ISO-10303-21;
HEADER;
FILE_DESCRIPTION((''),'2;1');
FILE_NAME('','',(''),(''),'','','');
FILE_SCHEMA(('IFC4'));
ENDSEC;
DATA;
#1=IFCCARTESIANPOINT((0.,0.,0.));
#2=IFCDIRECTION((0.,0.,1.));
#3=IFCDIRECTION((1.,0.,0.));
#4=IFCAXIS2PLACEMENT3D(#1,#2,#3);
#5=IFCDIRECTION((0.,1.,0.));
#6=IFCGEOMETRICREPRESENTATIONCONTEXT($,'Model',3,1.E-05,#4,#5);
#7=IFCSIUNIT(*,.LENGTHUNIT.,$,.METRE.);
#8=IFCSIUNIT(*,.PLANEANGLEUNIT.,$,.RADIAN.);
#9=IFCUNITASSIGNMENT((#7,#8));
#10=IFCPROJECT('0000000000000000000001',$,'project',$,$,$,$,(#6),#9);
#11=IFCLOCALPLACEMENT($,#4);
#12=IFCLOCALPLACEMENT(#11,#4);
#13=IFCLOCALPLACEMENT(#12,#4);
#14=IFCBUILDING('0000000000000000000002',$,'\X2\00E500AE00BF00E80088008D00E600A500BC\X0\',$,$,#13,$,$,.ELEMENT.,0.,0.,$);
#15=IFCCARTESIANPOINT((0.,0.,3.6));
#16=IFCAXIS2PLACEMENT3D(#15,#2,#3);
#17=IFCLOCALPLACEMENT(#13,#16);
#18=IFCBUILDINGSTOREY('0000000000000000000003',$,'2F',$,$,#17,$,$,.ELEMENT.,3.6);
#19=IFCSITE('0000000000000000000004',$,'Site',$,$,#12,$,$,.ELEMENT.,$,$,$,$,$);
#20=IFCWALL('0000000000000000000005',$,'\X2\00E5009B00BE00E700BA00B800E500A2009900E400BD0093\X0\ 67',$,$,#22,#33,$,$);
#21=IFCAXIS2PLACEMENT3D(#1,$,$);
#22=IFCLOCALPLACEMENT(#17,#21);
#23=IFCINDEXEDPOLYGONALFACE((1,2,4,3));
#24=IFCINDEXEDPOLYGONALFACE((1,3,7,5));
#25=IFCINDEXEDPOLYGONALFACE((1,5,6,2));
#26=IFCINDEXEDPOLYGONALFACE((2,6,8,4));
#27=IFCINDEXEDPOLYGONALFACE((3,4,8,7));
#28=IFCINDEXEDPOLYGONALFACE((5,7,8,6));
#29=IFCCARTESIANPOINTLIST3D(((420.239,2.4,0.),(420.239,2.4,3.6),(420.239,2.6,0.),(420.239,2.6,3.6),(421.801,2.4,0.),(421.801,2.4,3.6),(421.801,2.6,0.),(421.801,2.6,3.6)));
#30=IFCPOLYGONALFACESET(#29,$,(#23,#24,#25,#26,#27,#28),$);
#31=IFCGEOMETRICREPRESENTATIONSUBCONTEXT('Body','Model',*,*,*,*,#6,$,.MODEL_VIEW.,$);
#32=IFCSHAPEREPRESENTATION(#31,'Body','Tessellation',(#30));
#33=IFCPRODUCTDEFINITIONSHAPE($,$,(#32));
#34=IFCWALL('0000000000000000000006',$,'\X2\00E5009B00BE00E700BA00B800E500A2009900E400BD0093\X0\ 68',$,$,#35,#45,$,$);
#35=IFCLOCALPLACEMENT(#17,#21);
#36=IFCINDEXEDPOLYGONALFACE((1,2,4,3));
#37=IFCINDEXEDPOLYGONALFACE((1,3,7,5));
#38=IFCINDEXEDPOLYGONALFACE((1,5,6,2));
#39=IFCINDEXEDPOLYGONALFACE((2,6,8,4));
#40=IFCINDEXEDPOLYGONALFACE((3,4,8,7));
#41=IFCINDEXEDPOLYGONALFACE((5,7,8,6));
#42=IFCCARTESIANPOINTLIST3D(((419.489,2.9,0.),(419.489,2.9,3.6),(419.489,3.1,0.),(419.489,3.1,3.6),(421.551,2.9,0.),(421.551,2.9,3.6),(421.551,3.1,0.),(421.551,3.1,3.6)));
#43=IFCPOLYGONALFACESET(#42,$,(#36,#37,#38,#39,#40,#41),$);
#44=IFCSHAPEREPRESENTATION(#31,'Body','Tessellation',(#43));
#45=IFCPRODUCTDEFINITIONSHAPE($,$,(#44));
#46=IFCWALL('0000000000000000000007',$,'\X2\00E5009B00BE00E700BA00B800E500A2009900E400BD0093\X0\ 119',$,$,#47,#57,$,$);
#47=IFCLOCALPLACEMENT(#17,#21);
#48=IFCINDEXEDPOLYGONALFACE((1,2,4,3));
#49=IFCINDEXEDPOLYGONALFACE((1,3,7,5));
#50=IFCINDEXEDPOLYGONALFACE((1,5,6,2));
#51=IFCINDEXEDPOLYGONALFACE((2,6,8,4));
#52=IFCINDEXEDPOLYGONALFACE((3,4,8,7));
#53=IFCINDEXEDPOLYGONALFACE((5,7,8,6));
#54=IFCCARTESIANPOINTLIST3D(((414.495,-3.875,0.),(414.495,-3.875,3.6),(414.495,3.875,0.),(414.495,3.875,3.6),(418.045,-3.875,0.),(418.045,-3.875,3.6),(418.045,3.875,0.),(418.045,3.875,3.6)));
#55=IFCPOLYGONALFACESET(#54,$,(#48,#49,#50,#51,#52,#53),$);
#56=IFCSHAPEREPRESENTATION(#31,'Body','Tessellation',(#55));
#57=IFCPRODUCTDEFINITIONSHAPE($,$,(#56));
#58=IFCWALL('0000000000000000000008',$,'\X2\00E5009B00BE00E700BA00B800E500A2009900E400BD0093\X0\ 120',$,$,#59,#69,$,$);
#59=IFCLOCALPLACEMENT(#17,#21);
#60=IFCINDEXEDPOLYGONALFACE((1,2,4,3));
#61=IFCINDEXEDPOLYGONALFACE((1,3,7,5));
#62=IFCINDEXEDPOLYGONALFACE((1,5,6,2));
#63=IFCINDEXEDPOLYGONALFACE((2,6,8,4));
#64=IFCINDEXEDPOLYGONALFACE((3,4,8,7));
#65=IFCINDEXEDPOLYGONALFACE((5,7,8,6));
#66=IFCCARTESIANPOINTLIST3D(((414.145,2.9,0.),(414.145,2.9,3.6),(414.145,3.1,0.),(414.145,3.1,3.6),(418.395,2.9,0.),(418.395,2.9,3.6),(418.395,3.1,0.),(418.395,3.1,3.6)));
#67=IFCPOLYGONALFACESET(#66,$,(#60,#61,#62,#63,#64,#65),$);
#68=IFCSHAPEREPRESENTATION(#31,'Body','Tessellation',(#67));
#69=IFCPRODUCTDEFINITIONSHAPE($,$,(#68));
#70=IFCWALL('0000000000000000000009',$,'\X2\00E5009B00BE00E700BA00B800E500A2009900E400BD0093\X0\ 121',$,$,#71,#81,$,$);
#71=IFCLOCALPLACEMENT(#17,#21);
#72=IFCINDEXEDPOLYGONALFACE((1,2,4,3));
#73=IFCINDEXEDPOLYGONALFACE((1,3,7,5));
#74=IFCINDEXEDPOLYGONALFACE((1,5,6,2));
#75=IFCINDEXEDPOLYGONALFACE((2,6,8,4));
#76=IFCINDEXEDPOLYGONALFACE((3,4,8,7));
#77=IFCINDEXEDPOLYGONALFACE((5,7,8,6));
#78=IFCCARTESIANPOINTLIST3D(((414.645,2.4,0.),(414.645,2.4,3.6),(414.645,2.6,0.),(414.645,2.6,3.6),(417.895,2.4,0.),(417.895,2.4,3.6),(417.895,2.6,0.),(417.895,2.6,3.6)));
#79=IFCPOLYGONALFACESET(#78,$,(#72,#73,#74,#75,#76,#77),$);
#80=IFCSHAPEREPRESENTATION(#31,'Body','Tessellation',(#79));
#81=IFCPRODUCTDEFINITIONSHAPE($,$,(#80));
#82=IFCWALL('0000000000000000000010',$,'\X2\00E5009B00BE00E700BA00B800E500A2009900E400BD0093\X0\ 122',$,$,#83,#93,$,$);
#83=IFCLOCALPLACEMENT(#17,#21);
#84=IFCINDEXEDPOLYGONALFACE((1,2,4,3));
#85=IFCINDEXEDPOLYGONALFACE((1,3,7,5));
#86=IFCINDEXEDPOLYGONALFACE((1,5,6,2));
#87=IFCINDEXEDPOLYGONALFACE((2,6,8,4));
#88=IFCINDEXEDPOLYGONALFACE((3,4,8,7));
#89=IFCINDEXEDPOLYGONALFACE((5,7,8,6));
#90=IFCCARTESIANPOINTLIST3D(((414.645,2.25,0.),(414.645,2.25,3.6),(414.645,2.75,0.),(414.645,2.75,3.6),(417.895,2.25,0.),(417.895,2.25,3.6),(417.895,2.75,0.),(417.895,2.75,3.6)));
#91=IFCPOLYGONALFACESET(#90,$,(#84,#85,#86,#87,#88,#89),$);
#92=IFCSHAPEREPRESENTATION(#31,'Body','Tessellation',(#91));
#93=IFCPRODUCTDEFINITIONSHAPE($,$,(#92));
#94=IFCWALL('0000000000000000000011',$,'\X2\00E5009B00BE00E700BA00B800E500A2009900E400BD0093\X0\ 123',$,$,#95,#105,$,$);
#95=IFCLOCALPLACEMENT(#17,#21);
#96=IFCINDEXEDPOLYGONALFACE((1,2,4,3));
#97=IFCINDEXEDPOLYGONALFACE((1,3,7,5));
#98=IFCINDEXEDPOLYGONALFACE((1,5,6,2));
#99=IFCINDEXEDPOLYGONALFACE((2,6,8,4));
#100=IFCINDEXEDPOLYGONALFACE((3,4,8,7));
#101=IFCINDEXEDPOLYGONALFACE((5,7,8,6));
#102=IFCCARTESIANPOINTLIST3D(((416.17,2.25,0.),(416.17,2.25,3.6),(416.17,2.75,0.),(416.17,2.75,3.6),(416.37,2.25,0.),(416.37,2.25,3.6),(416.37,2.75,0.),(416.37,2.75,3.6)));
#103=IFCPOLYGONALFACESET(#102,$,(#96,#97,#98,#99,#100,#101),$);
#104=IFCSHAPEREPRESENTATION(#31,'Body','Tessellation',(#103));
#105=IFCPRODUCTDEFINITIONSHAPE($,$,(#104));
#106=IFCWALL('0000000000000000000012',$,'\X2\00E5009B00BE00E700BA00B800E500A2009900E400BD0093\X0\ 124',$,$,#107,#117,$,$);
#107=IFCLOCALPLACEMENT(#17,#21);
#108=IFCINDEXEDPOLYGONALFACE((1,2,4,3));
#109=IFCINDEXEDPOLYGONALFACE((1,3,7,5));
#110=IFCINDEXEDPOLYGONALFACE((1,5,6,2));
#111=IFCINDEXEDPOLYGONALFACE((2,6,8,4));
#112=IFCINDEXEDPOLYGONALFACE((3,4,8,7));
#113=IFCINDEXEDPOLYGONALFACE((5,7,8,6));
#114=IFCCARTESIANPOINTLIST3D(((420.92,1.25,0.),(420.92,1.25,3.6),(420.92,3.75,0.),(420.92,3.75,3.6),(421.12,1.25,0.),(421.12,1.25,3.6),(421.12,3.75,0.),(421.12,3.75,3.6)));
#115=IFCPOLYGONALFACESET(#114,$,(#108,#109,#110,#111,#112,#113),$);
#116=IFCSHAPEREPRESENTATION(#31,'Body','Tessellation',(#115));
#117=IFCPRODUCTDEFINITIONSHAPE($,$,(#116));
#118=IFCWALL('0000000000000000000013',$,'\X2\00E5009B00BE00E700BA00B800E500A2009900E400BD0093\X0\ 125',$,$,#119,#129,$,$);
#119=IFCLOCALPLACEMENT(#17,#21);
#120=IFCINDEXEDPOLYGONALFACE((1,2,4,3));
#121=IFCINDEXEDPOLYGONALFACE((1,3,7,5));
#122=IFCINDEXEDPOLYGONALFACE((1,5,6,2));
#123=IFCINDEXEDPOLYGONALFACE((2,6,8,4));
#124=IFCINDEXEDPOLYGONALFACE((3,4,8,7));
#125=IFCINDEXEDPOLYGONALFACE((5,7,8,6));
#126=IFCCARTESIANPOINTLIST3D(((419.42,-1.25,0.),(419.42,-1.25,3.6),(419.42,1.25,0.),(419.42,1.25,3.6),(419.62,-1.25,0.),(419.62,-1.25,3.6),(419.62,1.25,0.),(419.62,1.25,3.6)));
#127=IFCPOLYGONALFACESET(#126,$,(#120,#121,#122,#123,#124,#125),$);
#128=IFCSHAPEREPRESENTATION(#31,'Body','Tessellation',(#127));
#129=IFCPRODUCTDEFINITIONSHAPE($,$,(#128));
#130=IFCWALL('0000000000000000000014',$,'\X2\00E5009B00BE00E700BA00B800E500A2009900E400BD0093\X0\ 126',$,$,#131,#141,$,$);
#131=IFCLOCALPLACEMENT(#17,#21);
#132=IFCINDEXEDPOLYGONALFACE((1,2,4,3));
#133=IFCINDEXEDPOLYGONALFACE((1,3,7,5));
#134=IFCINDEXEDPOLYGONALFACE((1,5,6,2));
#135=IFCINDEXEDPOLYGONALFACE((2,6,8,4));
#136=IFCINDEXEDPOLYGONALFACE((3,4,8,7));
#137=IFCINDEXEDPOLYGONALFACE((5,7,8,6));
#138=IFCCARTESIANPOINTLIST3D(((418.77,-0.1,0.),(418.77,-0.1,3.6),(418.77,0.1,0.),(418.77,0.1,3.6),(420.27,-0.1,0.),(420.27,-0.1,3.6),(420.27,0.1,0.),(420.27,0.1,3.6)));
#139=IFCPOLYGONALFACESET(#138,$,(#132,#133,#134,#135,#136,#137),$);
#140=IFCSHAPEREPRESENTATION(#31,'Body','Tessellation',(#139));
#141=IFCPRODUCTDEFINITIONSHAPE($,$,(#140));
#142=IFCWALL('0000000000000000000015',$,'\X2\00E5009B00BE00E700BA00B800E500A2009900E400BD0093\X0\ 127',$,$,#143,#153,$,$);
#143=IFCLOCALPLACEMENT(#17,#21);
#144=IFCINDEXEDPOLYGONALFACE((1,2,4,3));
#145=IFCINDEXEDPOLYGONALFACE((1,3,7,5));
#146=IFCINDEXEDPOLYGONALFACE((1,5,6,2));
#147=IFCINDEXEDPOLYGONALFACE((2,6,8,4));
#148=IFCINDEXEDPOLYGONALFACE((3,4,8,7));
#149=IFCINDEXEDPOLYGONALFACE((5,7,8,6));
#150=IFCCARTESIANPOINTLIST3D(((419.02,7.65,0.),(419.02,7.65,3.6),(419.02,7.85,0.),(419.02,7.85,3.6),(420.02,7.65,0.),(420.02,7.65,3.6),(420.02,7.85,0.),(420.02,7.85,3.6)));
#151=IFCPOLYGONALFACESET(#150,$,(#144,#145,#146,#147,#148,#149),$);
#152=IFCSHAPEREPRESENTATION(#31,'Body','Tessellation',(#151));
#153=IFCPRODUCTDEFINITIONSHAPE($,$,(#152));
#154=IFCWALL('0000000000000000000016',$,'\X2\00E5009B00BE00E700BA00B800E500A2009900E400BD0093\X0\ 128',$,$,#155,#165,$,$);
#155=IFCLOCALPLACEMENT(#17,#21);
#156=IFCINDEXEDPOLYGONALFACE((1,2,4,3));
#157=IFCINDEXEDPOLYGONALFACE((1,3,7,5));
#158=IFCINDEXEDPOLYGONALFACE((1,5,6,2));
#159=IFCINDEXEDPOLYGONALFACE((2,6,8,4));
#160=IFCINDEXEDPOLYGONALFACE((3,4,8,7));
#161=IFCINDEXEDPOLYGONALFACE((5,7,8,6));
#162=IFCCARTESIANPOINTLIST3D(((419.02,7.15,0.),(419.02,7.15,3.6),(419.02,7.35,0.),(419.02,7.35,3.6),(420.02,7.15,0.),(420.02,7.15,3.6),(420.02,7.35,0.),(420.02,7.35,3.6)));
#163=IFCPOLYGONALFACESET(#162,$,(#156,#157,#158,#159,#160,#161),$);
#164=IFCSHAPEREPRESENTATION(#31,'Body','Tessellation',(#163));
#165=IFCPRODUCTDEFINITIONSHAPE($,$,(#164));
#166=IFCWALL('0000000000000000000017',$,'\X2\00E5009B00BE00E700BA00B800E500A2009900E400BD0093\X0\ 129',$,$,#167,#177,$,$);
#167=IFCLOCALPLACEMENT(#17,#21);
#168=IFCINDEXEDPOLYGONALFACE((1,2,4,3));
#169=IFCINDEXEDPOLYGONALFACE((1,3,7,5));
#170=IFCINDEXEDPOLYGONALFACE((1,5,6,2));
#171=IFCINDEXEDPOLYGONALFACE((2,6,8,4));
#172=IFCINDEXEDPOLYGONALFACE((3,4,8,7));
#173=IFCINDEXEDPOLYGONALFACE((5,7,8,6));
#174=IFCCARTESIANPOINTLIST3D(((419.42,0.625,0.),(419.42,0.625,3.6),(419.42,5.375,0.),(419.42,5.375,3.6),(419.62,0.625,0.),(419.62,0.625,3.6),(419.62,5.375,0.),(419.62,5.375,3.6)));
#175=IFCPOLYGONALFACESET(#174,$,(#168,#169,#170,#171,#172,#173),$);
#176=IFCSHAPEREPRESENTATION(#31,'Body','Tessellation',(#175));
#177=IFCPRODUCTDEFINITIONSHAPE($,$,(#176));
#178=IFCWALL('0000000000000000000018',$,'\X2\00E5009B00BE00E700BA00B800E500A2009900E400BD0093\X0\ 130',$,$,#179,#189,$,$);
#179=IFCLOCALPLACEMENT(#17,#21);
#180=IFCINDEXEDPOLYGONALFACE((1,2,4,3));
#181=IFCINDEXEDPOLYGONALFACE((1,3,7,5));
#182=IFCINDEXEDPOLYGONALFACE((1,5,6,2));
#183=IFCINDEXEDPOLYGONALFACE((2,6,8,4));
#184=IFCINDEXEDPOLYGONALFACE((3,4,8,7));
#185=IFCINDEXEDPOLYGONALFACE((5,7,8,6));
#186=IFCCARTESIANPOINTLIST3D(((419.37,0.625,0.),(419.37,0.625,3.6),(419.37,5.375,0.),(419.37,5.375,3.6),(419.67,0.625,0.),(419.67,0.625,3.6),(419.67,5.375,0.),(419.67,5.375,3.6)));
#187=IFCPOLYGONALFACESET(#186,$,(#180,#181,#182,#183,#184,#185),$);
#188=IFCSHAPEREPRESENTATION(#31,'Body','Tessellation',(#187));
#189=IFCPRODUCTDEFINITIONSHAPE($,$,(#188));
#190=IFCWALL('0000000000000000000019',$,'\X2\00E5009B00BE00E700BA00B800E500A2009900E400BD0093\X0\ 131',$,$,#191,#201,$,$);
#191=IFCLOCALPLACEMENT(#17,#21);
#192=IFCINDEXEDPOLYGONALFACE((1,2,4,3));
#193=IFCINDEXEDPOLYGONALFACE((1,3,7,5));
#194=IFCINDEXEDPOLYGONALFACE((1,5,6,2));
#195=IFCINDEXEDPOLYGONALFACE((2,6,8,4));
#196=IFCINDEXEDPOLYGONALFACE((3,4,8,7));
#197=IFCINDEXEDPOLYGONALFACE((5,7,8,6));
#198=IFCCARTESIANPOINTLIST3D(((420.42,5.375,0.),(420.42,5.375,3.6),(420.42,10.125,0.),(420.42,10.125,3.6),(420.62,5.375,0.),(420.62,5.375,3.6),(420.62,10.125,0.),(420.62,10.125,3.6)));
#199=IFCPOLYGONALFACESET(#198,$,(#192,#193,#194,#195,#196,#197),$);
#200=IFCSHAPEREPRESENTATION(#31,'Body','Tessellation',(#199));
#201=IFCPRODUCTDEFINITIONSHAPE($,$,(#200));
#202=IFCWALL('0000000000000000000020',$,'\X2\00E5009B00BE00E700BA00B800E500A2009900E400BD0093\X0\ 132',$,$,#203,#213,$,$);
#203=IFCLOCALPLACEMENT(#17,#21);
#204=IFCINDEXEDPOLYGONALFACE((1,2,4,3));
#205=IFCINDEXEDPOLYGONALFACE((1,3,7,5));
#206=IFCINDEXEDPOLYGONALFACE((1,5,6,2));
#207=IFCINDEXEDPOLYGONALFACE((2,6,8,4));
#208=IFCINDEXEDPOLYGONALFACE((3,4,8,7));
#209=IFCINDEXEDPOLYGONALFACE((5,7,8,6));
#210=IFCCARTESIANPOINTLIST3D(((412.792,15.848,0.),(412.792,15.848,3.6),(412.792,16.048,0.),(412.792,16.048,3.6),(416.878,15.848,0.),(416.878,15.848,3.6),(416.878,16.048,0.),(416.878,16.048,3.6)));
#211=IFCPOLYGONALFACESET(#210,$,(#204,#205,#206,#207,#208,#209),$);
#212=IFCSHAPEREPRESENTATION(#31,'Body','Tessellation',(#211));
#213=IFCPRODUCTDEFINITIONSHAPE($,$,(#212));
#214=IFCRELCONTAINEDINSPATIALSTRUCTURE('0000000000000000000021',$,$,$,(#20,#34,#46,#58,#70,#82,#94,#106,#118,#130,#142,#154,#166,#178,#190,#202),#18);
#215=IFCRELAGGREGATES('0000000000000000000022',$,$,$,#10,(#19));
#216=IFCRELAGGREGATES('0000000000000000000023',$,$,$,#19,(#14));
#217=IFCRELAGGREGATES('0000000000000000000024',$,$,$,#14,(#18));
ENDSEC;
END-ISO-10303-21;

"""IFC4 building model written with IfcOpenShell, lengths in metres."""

from ifc_helpers import new_model, si_unit, direction, frame, frame_2d, origin_with_axes, place, context, subcontext, project, spatial, rectangle, extrude, element, save


model = new_model("IFC4")

# Units and contexts
model_context = context("Model", 3, precision=1e-05, world=origin_with_axes(), true_north=direction((0.0, 1.0, 0.0)))
body_context = subcontext(model_context, "Body", "Model", "MODEL_VIEW")
ifc_project = project(units=[si_unit("LENGTHUNIT", "METRE"), si_unit("PLANEANGLEUNIT", "RADIAN")], contexts=[model_context])

# Site, building, storey
placement = place(None, origin_with_axes())
site_placement = place(placement, origin_with_axes())
site = spatial("IfcSite", under=ifc_project, at=site_placement, Name="Site", CompositionType="ELEMENT")
building_placement = place(site_placement, origin_with_axes())
building = spatial("IfcBuilding", under=site, at=building_placement, Name="å®¿è\u0088\u008dæ¥¼", CompositionType="ELEMENT", ElevationOfRefHeight=0.0, ElevationOfTerrain=0.0)
storey_placement = place(building_placement, frame((0.0, 0.0, 3.6), z_axis=(0.0, 0.0, 1.0), x_axis=(1.0, 0.0, 0.0)))
storey = spatial("IfcBuildingStorey", under=building, at=storey_placement, Name="2F", CompositionType="ELEMENT", Elevation=3.6)

# Walls
wall_1_placement = place(storey_placement, frame((421.02, 2.5, 0.0), z_axis=(0.0, 0.0, 1.0), x_axis=(1.0, 0.0, 0.0)))
element("IfcWall", 1, at=wall_1_placement, inside=storey, Name="å\u009b¾çº¸å¢\u0099ä½\u0093 67", context=body_context, shape_type="SweptSolid", body=[
    extrude(rectangle(XDim=1.562, YDim=0.2, at=frame_2d((0.0, 0.0), x_axis=(1.0, 0.0, 0.0))), frame((0.0, 0.0, 0.0), z_axis=(0.0, 0.0, 1.0)), (0.0, 0.0, 1.0), 3.6),
])
wall_2_placement = place(storey_placement, frame((420.52, 3.0, 0.0), z_axis=(0.0, 0.0, 1.0), x_axis=(1.0, 0.0, 0.0)))
element("IfcWall", 2, at=wall_2_placement, inside=storey, Name="å\u009b¾çº¸å¢\u0099ä½\u0093 68", context=body_context, shape_type="SweptSolid", body=[
    extrude(rectangle(XDim=2.062, YDim=0.2, at=frame_2d((0.0, 0.0), x_axis=(1.0, 0.0, 0.0))), frame((0.0, 0.0, 0.0), z_axis=(0.0, 0.0, 1.0)), (0.0, 0.0, 1.0), 3.6),
])
wall_3_placement = place(storey_placement, frame((416.27, 0.0, 0.0), z_axis=(0.0, 0.0, 1.0), x_axis=(1.0, 0.0, 0.0)))
element("IfcWall", 3, at=wall_3_placement, inside=storey, Name="å\u009b¾çº¸å¢\u0099ä½\u0093 119", context=body_context, shape_type="SweptSolid", body=[
    extrude(rectangle(XDim=3.55, YDim=7.75, at=frame_2d((0.0, 0.0), x_axis=(1.0, 0.0, 0.0))), frame((0.0, 0.0, 0.0), z_axis=(0.0, 0.0, 1.0)), (0.0, 0.0, 1.0), 3.6),
])
wall_4_placement = place(storey_placement, frame((416.27, 3.0, 0.0), z_axis=(0.0, 0.0, 1.0), x_axis=(1.0, 0.0, 0.0)))
element("IfcWall", 4, at=wall_4_placement, inside=storey, Name="å\u009b¾çº¸å¢\u0099ä½\u0093 120", context=body_context, shape_type="SweptSolid", body=[
    extrude(rectangle(XDim=4.25, YDim=0.2, at=frame_2d((0.0, 0.0), x_axis=(1.0, 0.0, 0.0))), frame((0.0, 0.0, 0.0), z_axis=(0.0, 0.0, 1.0)), (0.0, 0.0, 1.0), 3.6),
])
wall_5_placement = place(storey_placement, frame((416.27, 2.5, 0.0), z_axis=(0.0, 0.0, 1.0), x_axis=(1.0, 0.0, 0.0)))
element("IfcWall", 5, at=wall_5_placement, inside=storey, Name="å\u009b¾çº¸å¢\u0099ä½\u0093 121", context=body_context, shape_type="SweptSolid", body=[
    extrude(rectangle(XDim=3.25, YDim=0.2, at=frame_2d((0.0, 0.0), x_axis=(1.0, 0.0, 0.0))), frame((0.0, 0.0, 0.0), z_axis=(0.0, 0.0, 1.0)), (0.0, 0.0, 1.0), 3.6),
])
wall_6_placement = place(storey_placement, frame((416.27, 2.5, 0.0), z_axis=(0.0, 0.0, 1.0), x_axis=(1.0, 0.0, 0.0)))
element("IfcWall", 6, at=wall_6_placement, inside=storey, Name="å\u009b¾çº¸å¢\u0099ä½\u0093 122", context=body_context, shape_type="SweptSolid", body=[
    extrude(rectangle(XDim=3.25, YDim=0.5, at=frame_2d((0.0, 0.0), x_axis=(1.0, 0.0, 0.0))), frame((0.0, 0.0, 0.0), z_axis=(0.0, 0.0, 1.0)), (0.0, 0.0, 1.0), 3.6),
])
wall_7_placement = place(storey_placement, frame((416.27, 2.5, 0.0), z_axis=(0.0, 0.0, 1.0), x_axis=(0.0, 1.0, 0.0)))
element("IfcWall", 7, at=wall_7_placement, inside=storey, Name="å\u009b¾çº¸å¢\u0099ä½\u0093 123", context=body_context, shape_type="SweptSolid", body=[
    extrude(rectangle(XDim=0.5, YDim=0.2, at=frame_2d((0.0, 0.0), x_axis=(1.0, 0.0, 0.0))), frame((0.0, 0.0, 0.0), z_axis=(0.0, 0.0, 1.0)), (0.0, 0.0, 1.0), 3.6),
])
for number, where, z_axis, x_axis, name in (
    (8, (421.02, 2.5, 0.0), (0.0, 0.0, 1.0), (0.0, -1.0, 0.0), "å\u009b¾çº¸å¢\u0099ä½\u0093 124"),
    (9, (419.52, 0.0, 0.0), (0.0, 0.0, 1.0), (0.0, 1.0, 0.0), "å\u009b¾çº¸å¢\u0099ä½\u0093 125"),
):
    element("IfcWall", number, at=place(storey_placement, frame(where, z_axis=z_axis, x_axis=x_axis)), inside=storey, Name=name, context=body_context, shape_type="SweptSolid", body=[
        extrude(rectangle(XDim=2.5, YDim=0.2, at=frame_2d((0.0, 0.0), x_axis=(1.0, 0.0, 0.0))), frame((0.0, 0.0, 0.0), z_axis=(0.0, 0.0, 1.0)), (0.0, 0.0, 1.0), 3.6),
    ])
wall_8_placement = place(storey_placement, frame((419.52, 0.0, 0.0), z_axis=(0.0, 0.0, 1.0), x_axis=(1.0, 0.0, 0.0)))
element("IfcWall", 10, at=wall_8_placement, inside=storey, Name="å\u009b¾çº¸å¢\u0099ä½\u0093 126", context=body_context, shape_type="SweptSolid", body=[
    extrude(rectangle(XDim=1.5, YDim=0.2, at=frame_2d((0.0, 0.0), x_axis=(1.0, 0.0, 0.0))), frame((0.0, 0.0, 0.0), z_axis=(0.0, 0.0, 1.0)), (0.0, 0.0, 1.0), 3.6),
])
for number, where, z_axis, x_axis, name in (
    (11, (419.52, 7.75, 0.0), (0.0, 0.0, 1.0), (1.0, 0.0, 0.0), "å\u009b¾çº¸å¢\u0099ä½\u0093 127"),
    (12, (419.52, 7.25, 0.0), (0.0, 0.0, 1.0), (1.0, 0.0, 0.0), "å\u009b¾çº¸å¢\u0099ä½\u0093 128"),
):
    element("IfcWall", number, at=place(storey_placement, frame(where, z_axis=z_axis, x_axis=x_axis)), inside=storey, Name=name, context=body_context, shape_type="SweptSolid", body=[
        extrude(rectangle(XDim=1.0, YDim=0.2, at=frame_2d((0.0, 0.0), x_axis=(1.0, 0.0, 0.0))), frame((0.0, 0.0, 0.0), z_axis=(0.0, 0.0, 1.0)), (0.0, 0.0, 1.0), 3.6),
    ])
wall_9_placement = place(storey_placement, frame((419.52, 3.0, 0.0), z_axis=(0.0, 0.0, 1.0), x_axis=(0.0, 1.0, 0.0)))
element("IfcWall", 13, at=wall_9_placement, inside=storey, Name="å\u009b¾çº¸å¢\u0099ä½\u0093 129", context=body_context, shape_type="SweptSolid", body=[
    extrude(rectangle(XDim=4.75, YDim=0.2, at=frame_2d((0.0, 0.0), x_axis=(1.0, 0.0, 0.0))), frame((0.0, 0.0, 0.0), z_axis=(0.0, 0.0, 1.0)), (0.0, 0.0, 1.0), 3.6),
])
wall_10_placement = place(storey_placement, frame((419.52, 3.0, 0.0), z_axis=(0.0, 0.0, 1.0), x_axis=(1.0, 0.0, 0.0)))
element("IfcWall", 14, at=wall_10_placement, inside=storey, Name="å\u009b¾çº¸å¢\u0099ä½\u0093 130", context=body_context, shape_type="SweptSolid", body=[
    extrude(rectangle(XDim=0.3, YDim=4.75, at=frame_2d((0.0, 0.0), x_axis=(1.0, 0.0, 0.0))), frame((0.0, 0.0, 0.0), z_axis=(0.0, 0.0, 1.0)), (0.0, 0.0, 1.0), 3.6),
])
wall_11_placement = place(storey_placement, frame((420.52, 7.75, 0.0), z_axis=(0.0, 0.0, 1.0), x_axis=(0.0, -1.0, 0.0)))
element("IfcWall", 15, at=wall_11_placement, inside=storey, Name="å\u009b¾çº¸å¢\u0099ä½\u0093 131", context=body_context, shape_type="SweptSolid", body=[
    extrude(rectangle(XDim=4.75, YDim=0.2, at=frame_2d((0.0, 0.0), x_axis=(1.0, 0.0, 0.0))), frame((0.0, 0.0, 0.0), z_axis=(0.0, 0.0, 1.0)), (0.0, 0.0, 1.0), 3.6),
])
for number, where, z_axis, x_axis, name in (
    (16, (414.835, 15.948, 0.0), (0.0, 0.0, 1.0), (1.0, 0.0, 0.0), "å\u009b¾çº¸å¢\u0099ä½\u0093 132"),
):
    element("IfcWall", number, at=place(storey_placement, frame(where, z_axis=z_axis, x_axis=x_axis)), inside=storey, Name=name, context=body_context, shape_type="SweptSolid", body=[
        extrude(rectangle(XDim=4.086, YDim=0.2, at=frame_2d((0.0, 0.0), x_axis=(1.0, 0.0, 0.0))), frame((0.0, 0.0, 0.0), z_axis=(0.0, 0.0, 1.0)), (0.0, 0.0, 1.0), 3.6),
    ])

save(model, "model.ifc")
